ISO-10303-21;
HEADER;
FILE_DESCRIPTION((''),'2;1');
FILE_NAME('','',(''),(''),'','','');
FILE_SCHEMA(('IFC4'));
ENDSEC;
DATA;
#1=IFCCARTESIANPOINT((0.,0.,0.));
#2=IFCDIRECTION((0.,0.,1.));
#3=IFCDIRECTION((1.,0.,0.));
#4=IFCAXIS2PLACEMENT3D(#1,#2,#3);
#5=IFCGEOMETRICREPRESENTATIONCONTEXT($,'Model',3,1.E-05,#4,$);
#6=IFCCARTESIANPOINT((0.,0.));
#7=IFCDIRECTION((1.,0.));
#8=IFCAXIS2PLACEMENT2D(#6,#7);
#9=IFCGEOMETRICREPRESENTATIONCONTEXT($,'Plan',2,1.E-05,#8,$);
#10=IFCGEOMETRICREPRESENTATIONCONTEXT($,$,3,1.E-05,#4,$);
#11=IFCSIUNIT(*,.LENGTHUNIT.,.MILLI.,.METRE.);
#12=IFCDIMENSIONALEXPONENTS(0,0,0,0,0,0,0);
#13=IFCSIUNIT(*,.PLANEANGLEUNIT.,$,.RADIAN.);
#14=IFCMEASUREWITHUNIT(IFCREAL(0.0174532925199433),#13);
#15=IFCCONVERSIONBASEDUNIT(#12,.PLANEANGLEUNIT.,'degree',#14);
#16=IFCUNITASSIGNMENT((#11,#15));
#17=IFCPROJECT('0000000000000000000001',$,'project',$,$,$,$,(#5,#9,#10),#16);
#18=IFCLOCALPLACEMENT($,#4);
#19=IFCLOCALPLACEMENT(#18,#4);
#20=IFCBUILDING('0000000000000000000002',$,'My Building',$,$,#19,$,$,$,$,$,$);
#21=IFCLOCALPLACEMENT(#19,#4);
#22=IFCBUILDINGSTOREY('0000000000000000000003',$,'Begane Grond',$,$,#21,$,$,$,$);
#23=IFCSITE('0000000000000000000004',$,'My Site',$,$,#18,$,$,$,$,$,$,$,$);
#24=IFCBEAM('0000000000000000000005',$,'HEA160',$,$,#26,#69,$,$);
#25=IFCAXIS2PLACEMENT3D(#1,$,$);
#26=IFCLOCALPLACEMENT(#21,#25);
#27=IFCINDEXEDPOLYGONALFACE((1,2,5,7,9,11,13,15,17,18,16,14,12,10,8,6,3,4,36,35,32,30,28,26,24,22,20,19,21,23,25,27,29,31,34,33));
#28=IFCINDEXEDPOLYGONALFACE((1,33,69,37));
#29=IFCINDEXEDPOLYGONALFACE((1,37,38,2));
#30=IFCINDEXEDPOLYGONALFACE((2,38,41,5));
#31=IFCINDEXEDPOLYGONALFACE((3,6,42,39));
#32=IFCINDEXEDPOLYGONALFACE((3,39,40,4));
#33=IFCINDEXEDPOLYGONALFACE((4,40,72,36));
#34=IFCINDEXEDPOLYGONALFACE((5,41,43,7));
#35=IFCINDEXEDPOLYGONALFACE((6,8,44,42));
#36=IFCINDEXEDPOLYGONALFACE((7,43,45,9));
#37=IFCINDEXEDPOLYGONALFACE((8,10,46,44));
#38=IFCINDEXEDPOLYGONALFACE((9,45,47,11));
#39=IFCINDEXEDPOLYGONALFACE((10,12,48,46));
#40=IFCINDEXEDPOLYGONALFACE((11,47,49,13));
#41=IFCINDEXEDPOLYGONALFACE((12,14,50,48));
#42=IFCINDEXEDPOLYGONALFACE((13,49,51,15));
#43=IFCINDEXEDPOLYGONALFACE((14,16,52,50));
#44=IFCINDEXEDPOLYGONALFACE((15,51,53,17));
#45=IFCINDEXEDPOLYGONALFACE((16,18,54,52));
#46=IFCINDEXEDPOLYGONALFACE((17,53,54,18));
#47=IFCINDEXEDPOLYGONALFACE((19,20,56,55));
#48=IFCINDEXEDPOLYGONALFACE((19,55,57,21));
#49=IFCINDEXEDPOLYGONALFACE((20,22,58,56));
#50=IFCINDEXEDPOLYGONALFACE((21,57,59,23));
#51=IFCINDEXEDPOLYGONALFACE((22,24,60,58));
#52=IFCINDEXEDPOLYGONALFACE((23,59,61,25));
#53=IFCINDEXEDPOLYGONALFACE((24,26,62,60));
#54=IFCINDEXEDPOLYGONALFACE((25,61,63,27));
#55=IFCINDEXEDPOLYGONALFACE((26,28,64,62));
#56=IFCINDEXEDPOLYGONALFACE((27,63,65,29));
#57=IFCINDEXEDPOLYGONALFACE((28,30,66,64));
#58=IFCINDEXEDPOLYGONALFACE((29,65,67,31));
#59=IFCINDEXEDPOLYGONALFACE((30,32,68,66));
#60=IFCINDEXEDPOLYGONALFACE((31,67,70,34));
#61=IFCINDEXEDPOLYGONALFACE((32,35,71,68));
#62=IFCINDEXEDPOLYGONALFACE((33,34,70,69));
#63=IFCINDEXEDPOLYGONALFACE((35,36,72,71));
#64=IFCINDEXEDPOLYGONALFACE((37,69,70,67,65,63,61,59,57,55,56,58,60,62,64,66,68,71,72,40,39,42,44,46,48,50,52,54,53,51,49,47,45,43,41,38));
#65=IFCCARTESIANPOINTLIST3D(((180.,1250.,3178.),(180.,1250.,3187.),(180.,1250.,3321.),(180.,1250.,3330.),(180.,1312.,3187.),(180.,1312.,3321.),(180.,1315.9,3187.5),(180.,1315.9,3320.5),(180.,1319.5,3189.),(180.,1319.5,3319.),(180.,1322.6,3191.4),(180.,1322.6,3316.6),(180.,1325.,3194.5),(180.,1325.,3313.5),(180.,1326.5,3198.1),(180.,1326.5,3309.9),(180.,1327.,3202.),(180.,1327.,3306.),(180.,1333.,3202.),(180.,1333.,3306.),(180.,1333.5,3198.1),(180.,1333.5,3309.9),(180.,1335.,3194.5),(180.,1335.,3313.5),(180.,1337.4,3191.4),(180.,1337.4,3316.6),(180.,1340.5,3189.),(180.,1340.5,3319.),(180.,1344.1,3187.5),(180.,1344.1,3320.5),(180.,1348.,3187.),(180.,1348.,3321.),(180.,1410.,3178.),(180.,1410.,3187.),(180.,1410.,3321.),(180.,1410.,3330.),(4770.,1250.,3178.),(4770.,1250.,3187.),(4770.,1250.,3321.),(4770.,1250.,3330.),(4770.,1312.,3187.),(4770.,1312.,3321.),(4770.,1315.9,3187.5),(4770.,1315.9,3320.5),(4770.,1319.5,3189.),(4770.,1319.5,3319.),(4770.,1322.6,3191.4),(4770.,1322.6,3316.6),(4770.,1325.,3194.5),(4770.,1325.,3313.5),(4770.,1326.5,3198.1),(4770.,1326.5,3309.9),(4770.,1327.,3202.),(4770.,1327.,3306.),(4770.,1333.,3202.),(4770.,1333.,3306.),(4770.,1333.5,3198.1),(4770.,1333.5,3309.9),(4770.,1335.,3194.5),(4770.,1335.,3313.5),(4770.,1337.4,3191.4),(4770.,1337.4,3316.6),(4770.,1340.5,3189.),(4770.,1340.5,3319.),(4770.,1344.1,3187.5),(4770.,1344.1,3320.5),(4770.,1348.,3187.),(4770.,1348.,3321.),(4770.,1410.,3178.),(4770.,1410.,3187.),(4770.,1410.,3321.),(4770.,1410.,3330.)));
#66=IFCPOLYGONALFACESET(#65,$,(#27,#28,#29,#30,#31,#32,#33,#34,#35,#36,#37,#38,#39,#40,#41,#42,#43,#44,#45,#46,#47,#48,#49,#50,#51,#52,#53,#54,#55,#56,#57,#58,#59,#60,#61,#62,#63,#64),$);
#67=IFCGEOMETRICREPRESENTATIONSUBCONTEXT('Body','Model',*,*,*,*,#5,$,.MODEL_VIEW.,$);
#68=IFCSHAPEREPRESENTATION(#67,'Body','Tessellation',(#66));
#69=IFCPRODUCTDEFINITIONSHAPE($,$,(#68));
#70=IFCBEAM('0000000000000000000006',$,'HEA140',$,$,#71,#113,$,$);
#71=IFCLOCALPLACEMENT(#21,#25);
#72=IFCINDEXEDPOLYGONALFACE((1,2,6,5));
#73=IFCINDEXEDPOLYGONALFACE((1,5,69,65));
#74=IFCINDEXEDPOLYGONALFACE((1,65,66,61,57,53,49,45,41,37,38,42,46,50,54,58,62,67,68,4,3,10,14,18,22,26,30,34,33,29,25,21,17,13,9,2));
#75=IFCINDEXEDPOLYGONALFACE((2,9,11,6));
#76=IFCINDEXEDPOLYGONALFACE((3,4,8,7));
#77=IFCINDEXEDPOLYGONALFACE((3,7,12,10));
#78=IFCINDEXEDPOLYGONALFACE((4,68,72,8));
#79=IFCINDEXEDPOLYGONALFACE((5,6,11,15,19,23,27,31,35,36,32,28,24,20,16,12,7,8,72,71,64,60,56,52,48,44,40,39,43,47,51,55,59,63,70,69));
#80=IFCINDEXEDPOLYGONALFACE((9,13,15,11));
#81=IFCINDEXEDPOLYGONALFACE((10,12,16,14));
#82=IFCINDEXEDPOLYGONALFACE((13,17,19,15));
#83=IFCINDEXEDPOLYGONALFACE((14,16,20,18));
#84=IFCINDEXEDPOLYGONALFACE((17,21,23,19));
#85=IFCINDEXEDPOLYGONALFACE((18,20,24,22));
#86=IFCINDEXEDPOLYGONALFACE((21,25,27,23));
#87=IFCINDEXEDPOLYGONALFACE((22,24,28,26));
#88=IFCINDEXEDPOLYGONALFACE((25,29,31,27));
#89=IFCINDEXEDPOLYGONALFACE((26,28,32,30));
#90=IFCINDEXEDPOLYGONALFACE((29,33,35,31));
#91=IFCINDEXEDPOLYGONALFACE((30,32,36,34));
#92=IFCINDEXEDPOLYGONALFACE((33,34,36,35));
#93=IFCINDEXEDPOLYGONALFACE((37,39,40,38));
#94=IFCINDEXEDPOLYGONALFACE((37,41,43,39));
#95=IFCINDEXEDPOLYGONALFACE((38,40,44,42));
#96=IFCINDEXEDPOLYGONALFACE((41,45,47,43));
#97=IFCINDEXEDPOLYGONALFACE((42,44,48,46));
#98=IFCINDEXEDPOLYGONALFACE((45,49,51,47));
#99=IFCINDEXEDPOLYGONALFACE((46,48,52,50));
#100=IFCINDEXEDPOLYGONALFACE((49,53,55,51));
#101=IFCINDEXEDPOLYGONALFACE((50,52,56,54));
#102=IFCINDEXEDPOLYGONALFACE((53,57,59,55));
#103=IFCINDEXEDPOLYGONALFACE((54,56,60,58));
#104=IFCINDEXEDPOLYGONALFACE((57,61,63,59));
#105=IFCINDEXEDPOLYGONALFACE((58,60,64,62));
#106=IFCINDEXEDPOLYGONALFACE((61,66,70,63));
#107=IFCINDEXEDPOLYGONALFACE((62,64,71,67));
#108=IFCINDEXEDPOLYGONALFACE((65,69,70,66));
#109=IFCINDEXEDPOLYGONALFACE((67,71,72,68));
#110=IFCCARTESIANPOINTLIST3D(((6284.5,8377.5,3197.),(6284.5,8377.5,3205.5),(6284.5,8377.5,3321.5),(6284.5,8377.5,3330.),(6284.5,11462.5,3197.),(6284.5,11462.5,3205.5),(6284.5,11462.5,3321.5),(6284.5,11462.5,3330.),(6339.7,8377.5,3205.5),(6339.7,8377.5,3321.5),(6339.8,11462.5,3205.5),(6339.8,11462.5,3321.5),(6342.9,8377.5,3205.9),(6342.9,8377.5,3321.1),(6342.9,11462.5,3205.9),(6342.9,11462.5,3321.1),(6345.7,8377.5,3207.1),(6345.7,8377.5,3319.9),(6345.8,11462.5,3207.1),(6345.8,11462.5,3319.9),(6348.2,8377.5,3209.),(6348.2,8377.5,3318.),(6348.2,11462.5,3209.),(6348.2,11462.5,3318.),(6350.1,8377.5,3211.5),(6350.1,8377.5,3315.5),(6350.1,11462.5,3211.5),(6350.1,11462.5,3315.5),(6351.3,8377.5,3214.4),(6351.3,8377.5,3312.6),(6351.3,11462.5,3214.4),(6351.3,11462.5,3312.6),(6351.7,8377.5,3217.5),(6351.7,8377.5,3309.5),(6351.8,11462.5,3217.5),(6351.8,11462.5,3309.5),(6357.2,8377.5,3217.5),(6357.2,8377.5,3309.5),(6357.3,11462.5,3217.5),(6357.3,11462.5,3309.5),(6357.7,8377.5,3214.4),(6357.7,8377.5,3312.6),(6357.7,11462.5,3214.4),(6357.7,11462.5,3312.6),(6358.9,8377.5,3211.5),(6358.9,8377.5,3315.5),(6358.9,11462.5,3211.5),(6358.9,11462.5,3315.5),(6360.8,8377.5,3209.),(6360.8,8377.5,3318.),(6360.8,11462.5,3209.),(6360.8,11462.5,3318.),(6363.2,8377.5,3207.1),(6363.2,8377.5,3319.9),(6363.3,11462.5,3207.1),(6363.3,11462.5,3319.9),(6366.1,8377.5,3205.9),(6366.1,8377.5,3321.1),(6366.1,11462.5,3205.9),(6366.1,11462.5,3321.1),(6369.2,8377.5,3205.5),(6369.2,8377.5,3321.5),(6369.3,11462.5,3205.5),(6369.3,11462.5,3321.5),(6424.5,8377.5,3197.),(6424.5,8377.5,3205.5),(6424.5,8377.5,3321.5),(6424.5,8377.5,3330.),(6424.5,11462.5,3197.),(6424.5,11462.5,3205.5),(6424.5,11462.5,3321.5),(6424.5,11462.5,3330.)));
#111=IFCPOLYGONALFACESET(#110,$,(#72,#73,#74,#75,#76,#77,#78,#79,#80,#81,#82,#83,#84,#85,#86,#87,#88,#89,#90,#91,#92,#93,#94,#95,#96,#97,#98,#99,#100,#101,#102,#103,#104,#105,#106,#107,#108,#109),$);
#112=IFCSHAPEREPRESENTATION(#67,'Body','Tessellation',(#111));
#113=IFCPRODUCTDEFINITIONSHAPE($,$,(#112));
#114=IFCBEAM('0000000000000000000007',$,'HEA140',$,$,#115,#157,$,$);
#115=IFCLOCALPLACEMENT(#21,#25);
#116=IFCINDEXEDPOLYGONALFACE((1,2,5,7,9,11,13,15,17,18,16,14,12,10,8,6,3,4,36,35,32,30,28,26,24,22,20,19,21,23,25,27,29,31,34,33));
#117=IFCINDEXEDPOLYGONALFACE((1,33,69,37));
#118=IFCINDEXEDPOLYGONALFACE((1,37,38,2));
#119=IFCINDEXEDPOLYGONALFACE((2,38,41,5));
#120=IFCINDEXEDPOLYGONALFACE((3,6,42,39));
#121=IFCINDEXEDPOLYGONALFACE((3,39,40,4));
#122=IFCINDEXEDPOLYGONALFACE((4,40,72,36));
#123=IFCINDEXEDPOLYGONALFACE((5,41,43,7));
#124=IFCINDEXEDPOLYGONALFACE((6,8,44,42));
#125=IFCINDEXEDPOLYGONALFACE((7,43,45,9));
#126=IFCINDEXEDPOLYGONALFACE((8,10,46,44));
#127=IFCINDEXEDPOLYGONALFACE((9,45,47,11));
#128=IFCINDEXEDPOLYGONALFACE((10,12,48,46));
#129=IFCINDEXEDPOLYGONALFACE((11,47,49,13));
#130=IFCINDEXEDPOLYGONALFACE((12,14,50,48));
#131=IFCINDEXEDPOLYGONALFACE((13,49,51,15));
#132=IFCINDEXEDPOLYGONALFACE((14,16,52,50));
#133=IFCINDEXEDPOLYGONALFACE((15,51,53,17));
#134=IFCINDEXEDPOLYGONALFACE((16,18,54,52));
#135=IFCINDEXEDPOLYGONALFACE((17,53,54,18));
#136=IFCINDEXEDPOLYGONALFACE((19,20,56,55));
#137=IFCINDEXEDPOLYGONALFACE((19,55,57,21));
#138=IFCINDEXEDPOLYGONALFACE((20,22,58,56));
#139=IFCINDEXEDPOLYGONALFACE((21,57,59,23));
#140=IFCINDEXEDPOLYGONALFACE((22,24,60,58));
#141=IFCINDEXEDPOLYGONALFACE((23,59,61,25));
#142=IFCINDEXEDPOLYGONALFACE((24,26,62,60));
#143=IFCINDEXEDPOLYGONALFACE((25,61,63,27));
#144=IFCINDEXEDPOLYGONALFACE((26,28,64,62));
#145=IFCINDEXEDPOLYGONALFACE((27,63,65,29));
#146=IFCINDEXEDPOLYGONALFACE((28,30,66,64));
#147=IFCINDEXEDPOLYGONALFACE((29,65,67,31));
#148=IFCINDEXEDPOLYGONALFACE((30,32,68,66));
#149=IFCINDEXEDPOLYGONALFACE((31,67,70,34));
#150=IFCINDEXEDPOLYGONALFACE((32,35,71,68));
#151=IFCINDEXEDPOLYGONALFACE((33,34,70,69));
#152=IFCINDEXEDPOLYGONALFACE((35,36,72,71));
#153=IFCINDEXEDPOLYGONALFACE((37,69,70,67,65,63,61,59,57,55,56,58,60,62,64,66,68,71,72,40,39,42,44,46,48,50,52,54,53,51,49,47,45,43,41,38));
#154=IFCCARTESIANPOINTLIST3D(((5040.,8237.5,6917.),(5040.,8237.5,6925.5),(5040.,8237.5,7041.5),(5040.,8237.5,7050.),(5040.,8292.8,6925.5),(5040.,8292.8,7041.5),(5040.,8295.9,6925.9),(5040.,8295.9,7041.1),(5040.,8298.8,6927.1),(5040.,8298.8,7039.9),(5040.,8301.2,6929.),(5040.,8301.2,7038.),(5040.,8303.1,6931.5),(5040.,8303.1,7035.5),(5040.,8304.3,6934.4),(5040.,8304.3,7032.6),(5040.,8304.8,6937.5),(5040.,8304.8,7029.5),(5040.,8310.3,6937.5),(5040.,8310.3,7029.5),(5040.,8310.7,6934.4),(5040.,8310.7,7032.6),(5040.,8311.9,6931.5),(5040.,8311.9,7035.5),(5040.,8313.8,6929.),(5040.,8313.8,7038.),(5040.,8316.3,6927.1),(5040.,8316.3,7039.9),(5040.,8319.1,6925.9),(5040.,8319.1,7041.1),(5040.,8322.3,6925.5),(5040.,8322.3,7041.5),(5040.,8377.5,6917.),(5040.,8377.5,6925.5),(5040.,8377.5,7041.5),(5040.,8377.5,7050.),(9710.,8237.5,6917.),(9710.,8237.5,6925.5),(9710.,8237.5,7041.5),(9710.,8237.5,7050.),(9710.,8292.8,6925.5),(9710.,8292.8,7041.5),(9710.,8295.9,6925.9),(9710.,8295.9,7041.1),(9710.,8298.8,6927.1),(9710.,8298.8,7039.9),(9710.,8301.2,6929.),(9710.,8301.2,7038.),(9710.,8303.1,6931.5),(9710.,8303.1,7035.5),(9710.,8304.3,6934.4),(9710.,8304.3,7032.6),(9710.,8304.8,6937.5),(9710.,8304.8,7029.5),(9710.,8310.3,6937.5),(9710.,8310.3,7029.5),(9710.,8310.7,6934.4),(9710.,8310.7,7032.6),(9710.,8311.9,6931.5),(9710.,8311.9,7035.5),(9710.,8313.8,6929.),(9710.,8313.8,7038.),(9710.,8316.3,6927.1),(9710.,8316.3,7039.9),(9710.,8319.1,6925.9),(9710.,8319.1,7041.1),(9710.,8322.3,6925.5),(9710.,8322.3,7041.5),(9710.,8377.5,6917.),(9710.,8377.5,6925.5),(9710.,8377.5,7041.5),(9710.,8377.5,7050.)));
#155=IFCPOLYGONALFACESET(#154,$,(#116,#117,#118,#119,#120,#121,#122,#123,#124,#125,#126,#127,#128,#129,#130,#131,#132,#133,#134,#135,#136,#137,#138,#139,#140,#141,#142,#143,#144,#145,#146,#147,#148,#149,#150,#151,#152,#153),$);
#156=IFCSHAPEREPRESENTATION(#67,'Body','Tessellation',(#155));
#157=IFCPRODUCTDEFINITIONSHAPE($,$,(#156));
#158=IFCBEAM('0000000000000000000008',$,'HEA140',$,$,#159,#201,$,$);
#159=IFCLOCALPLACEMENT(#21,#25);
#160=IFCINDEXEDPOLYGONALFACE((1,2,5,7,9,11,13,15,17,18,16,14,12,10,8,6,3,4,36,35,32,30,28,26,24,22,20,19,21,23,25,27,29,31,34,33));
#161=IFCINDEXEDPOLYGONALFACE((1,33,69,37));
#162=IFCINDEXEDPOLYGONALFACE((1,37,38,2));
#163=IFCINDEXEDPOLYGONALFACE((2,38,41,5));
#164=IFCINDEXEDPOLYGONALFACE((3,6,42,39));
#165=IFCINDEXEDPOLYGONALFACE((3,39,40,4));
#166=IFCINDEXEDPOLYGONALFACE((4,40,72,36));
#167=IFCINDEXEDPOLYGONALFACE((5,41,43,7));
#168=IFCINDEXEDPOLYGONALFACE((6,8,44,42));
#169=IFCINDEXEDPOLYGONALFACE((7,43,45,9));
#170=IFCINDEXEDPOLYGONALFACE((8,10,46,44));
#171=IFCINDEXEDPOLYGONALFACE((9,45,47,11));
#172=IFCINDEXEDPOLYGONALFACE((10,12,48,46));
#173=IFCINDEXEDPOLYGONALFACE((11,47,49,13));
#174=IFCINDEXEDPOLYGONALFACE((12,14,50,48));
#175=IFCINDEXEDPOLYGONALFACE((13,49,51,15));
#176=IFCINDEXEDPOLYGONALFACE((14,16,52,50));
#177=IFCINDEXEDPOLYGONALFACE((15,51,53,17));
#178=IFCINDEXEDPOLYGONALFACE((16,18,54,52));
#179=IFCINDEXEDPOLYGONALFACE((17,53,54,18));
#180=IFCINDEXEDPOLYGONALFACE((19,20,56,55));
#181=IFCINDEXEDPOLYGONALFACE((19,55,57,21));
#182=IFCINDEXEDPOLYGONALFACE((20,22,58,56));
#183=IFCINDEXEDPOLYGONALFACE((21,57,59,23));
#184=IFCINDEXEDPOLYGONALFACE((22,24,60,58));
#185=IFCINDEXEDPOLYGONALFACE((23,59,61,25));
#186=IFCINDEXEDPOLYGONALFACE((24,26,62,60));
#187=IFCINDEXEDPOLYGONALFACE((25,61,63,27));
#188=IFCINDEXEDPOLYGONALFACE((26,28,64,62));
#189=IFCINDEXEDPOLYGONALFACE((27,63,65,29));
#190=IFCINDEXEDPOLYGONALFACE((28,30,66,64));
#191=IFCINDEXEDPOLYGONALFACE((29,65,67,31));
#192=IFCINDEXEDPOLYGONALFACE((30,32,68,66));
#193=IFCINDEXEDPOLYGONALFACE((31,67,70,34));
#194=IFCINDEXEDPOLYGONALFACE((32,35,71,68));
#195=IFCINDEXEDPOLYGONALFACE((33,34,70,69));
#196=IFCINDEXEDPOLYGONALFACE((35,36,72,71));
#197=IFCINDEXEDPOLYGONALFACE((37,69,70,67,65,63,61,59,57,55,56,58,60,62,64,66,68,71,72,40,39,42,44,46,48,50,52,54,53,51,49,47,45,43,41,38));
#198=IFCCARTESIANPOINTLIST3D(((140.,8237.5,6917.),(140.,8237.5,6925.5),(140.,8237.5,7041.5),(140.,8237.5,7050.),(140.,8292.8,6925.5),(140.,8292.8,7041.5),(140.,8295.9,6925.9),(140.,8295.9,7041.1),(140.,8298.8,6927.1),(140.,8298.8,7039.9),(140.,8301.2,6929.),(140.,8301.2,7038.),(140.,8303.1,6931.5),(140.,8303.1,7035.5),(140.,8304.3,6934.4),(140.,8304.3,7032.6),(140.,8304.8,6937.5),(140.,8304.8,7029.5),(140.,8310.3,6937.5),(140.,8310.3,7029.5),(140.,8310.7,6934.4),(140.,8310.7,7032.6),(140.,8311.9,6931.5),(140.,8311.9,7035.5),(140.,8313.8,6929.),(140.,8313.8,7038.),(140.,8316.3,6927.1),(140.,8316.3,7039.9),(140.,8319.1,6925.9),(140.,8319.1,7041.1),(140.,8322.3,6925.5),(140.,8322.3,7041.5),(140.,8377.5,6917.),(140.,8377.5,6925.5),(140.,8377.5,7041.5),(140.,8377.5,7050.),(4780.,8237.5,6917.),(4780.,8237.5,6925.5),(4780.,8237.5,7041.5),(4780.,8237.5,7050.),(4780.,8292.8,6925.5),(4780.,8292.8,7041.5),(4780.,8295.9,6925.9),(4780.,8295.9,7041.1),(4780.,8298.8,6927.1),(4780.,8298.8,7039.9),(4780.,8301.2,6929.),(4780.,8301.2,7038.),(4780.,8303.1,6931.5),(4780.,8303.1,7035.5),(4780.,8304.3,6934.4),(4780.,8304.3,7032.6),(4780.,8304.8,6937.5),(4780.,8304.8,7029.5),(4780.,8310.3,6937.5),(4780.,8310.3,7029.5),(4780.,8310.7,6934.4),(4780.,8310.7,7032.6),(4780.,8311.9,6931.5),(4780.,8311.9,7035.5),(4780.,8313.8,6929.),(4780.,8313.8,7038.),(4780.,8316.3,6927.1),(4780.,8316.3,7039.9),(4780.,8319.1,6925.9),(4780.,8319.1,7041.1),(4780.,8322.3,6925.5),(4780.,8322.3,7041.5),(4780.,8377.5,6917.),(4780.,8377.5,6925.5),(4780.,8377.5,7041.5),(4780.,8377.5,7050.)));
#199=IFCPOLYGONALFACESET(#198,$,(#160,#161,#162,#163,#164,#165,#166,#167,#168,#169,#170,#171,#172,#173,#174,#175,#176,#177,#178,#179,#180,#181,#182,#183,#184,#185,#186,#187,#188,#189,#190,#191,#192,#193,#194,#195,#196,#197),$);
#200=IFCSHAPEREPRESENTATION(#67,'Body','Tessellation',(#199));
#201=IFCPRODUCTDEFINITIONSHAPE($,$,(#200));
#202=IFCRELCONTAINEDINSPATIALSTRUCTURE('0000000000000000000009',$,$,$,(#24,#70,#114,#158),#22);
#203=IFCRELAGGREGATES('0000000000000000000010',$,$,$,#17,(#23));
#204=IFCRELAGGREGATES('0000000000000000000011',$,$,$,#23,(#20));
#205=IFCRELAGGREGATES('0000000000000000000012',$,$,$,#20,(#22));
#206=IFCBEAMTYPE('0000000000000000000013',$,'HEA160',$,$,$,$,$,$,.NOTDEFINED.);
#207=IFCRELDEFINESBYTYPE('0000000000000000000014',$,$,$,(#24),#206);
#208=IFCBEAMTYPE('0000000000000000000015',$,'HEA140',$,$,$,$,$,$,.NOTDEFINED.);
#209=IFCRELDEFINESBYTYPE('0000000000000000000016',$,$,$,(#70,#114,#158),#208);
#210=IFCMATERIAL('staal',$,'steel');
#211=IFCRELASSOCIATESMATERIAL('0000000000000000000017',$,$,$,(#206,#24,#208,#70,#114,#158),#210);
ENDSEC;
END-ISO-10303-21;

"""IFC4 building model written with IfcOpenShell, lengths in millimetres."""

from ifc_helpers import new_model, entity, si_unit, converted_unit, frame, origin_with_axes, origin_2d_with_axis, place, context, subcontext, project, spatial, i_section, extrude, material, material_profile, profile_set, profile_usage, type_object, element, save


model = new_model("IFC4")

# Units and contexts
model_context = context("Model", 3, precision=1e-05, world=origin_with_axes())
plan_context = context("Plan", 2, precision=1e-05, world=origin_2d_with_axis())
context_of_model = context(None, 3, precision=1e-05, world=origin_with_axes())
body_context = subcontext(model_context, "Body", "Model", "MODEL_VIEW")
ifc_project = project(units=[si_unit("LENGTHUNIT", "METRE", prefix="MILLI"), converted_unit("PLANEANGLEUNIT", "degree", entity("IfcReal", 0.0174532925199433), si_unit("PLANEANGLEUNIT", "RADIAN"), dimensions=[0, 0, 0, 0, 0, 0, 0])], contexts=[model_context, plan_context, context_of_model])

# Site, building, storey
site_placement = place(None, origin_with_axes())
site = spatial("IfcSite", under=ifc_project, at=site_placement, Name="My Site")
building_placement = place(site_placement, origin_with_axes())
building = spatial("IfcBuilding", under=site, at=building_placement, Name="My Building")
storey_placement = place(building_placement, origin_with_axes())
storey = spatial("IfcBuildingStorey", under=building, at=storey_placement, Name="Begane Grond")

# Shared definitions
ifc_material = material(Name="staal", Category="steel")

# Beams
ifc_material_profile_1 = material_profile(ifc_material, i_section(OverallWidth=160.0, OverallDepth=152.0, WebThickness=6.0, FlangeThickness=9.0, FilletRadius=15.0))
ifc_profile_set_1 = profile_set([ifc_material_profile_1], Name="HEA160")
ifc_profile_usage_1 = profile_usage(ifc_profile_set_1, cardinal=5)
beam_type_1 = type_object("IfcBeamType", Name="HEA160", PredefinedType="NOTDEFINED", material=ifc_profile_set_1)
beam_1_placement = place(storey_placement, frame((180.0, 1330.0, 3254.0), z_axis=(1.0, 0.0, 0.0), x_axis=(0.0, 1.0, 0.0)))
element("IfcBeam", 1, at=beam_1_placement, inside=storey, type_object=beam_type_1, material=ifc_profile_usage_1, Name="HEA160", context=body_context, shape_type="SweptSolid", body=[
    extrude(i_section(OverallWidth=160.0, OverallDepth=152.0, WebThickness=6.0, FlangeThickness=9.0, FilletRadius=15.0), origin_with_axes(), (0.0, 0.0, 1.0), 4590.0),
])
ifc_material_profile_2 = material_profile(ifc_material, i_section(OverallWidth=140.0, OverallDepth=133.0, WebThickness=5.5, FlangeThickness=8.5, FilletRadius=12.0))
ifc_profile_set_2 = profile_set([ifc_material_profile_2], Name="HEA140")
ifc_profile_usage_2 = profile_usage(ifc_profile_set_2)
beam_type_2 = type_object("IfcBeamType", Name="HEA140", PredefinedType="NOTDEFINED", material=ifc_profile_set_2)
beam_2_placement = place(storey_placement, frame((6354.5, 8377.5, 3263.5), z_axis=(0.0, 1.0, 0.0), x_axis=(-1.0, 0.0, 0.0)))
element("IfcBeam", 2, at=beam_2_placement, inside=storey, type_object=beam_type_2, material=ifc_profile_usage_2, Name="HEA140", context=body_context, shape_type="SweptSolid", body=[
    extrude(i_section(OverallWidth=140.0, OverallDepth=133.0, WebThickness=5.5, FlangeThickness=8.5, FilletRadius=12.0), origin_with_axes(), (0.0, 0.0, 1.0), 3085.0),
])
ifc_profile_usage_3 = profile_usage(ifc_profile_set_2)
beam_3_placement = place(storey_placement, frame((9710.0, 8307.5, 6983.5), z_axis=(-1.0, 0.0, 0.0), x_axis=(0.0, -1.0, 0.0)))
element("IfcBeam", 3, at=beam_3_placement, inside=storey, type_object=beam_type_2, material=ifc_profile_usage_3, Name="HEA140", context=body_context, shape_type="SweptSolid", body=[
    extrude(i_section(OverallWidth=140.0, OverallDepth=133.0, WebThickness=5.5, FlangeThickness=8.5, FilletRadius=12.0), origin_with_axes(), (0.0, 0.0, 1.0), 4670.0),
])
ifc_profile_usage_4 = profile_usage(ifc_profile_set_2)
beam_4_placement = place(storey_placement, frame((4780.0, 8307.5, 6983.5), z_axis=(-1.0, 0.0, 0.0), x_axis=(0.0, -1.0, 0.0)))
element("IfcBeam", 4, at=beam_4_placement, inside=storey, type_object=beam_type_2, material=ifc_profile_usage_4, Name="HEA140", context=body_context, shape_type="SweptSolid", body=[
    extrude(i_section(OverallWidth=140.0, OverallDepth=133.0, WebThickness=5.5, FlangeThickness=8.5, FilletRadius=12.0), origin_with_axes(), (0.0, 0.0, 1.0), 4640.0),
])

save(model, "model.ifc")
